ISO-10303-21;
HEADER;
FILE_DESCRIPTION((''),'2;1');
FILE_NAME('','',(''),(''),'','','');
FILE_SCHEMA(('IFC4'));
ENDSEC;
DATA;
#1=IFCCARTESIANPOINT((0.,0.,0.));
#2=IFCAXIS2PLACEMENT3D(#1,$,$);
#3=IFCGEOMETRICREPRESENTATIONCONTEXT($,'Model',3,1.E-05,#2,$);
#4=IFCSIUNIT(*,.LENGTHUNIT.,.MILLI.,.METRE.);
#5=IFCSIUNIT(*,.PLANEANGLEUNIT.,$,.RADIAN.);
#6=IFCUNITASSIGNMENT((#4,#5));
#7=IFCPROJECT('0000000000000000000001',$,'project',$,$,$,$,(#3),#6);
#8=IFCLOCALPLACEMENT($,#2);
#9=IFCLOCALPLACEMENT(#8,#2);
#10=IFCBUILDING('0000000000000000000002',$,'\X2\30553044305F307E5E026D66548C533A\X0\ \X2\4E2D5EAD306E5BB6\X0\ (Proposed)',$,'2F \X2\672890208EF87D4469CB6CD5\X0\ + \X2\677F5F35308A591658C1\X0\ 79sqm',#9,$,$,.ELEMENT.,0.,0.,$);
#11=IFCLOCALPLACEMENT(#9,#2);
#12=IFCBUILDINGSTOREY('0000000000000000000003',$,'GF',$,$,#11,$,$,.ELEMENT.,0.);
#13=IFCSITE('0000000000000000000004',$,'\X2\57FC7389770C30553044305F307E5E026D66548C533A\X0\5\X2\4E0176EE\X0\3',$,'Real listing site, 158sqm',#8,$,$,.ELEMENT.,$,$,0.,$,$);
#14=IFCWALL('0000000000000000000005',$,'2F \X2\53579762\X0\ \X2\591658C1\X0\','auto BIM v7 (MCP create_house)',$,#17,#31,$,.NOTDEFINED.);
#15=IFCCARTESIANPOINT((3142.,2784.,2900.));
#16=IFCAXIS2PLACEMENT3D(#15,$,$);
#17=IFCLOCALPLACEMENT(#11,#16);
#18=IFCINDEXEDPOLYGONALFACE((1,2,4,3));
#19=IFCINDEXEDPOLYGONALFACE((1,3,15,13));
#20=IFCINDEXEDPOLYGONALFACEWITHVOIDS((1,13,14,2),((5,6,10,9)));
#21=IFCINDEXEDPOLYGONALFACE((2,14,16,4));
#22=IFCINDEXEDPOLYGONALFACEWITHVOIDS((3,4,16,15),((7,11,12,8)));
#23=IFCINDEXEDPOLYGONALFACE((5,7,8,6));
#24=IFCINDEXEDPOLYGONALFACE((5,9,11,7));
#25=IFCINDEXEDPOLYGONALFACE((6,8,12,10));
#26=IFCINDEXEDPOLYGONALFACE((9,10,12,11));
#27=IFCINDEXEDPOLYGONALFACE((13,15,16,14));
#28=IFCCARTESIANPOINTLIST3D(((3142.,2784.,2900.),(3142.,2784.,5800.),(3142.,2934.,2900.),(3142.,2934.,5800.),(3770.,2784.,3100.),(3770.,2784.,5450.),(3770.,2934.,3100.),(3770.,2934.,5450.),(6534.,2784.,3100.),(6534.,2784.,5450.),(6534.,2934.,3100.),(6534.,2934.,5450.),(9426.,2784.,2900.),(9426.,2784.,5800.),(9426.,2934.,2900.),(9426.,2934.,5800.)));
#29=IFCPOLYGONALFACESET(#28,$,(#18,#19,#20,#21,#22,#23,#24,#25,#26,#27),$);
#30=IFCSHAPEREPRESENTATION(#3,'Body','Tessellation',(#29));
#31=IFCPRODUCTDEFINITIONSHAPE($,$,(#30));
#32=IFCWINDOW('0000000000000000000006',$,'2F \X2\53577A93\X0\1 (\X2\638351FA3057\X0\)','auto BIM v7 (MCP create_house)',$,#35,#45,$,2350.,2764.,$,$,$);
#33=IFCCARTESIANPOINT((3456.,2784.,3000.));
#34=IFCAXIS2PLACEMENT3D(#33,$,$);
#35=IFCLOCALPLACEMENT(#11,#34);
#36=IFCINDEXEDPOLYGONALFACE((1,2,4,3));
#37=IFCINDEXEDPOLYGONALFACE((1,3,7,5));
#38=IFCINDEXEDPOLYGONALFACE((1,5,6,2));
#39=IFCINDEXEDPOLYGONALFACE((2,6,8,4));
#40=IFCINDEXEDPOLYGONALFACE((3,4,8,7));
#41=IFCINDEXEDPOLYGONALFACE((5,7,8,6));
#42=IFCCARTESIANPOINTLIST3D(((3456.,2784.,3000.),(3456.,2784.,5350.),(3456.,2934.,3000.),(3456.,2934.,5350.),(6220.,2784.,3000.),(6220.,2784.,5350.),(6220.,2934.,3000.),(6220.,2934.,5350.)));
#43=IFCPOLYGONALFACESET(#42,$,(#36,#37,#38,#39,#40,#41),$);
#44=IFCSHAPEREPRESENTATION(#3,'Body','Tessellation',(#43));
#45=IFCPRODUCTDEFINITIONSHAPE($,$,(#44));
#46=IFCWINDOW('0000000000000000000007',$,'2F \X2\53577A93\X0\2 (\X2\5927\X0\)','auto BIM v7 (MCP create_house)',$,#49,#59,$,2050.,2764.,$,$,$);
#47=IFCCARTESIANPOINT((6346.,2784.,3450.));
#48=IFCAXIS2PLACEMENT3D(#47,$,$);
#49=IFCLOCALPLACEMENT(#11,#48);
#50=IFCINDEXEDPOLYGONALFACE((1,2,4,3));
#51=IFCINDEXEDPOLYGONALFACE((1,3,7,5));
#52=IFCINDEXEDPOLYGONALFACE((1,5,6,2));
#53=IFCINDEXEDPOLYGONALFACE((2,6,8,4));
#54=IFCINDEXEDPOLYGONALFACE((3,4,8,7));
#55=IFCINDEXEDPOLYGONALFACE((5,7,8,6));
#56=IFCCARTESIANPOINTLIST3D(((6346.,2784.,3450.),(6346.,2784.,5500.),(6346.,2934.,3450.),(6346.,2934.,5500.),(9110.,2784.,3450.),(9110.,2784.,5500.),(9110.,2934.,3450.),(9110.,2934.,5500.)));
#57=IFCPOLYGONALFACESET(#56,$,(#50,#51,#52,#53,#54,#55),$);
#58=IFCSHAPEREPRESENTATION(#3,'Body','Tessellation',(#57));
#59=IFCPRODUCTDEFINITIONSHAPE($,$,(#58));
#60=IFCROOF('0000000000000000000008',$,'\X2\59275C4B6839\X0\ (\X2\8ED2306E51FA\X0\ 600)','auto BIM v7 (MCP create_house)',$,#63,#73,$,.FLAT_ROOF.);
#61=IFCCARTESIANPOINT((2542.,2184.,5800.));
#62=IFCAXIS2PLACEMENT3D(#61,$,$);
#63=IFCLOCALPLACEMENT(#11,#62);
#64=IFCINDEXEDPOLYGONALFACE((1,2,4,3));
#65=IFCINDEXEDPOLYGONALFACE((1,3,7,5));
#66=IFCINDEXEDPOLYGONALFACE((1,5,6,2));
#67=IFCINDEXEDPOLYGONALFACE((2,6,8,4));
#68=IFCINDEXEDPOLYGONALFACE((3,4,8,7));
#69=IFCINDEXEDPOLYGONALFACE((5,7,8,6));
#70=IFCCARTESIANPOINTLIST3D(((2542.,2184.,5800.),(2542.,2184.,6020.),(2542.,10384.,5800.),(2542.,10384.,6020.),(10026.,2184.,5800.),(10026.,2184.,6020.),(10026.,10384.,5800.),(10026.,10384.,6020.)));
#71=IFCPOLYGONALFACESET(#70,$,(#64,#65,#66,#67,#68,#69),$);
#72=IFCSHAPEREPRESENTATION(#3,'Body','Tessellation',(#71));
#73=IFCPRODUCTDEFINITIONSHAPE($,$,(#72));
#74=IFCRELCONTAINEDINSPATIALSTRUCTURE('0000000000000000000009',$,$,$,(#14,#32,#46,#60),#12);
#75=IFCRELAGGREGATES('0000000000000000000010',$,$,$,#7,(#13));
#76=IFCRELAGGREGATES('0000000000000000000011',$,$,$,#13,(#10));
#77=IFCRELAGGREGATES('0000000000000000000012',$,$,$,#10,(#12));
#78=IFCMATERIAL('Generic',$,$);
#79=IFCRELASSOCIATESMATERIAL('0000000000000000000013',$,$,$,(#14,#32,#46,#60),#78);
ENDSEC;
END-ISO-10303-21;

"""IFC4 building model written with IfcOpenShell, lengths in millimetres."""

from ifc_helpers import new_model, si_unit, frame, frame_2d, origin, place, context, project, spatial, rectangle, extrude, material, element, fill, save


model = new_model("IFC4")

# Units and contexts
model_context = context("Model", 3, precision=1e-05, world=origin())
ifc_project = project(units=[si_unit("LENGTHUNIT", "METRE", prefix="MILLI"), si_unit("PLANEANGLEUNIT", "RADIAN")], contexts=[model_context])

# Site, building, storey
site_placement = place(None, origin())
site = spatial("IfcSite", under=ifc_project, at=site_placement, Name="埼玉県さいたま市浦和区5丁目3", ObjectType="Real listing site, 158sqm", CompositionType="ELEMENT", RefElevation=0.0)
building_placement = place(site_placement, origin())
building = spatial("IfcBuilding", under=site, at=building_placement, Name="さいたま市浦和区 中庭の家 (Proposed)", ObjectType="2F 木造軸組構法 + 板張り外壁 79sqm", CompositionType="ELEMENT", ElevationOfRefHeight=0.0, ElevationOfTerrain=0.0)
storey_placement = place(building_placement, origin())
storey = spatial("IfcBuildingStorey", under=building, at=storey_placement, Name="GF", CompositionType="ELEMENT", Elevation=0.0)

# Shared definitions
ifc_material = material(Name="Generic")

# Wall, openings, windows
wall_1_placement = place(storey_placement, frame((3142.0, 2784.0, 2900.0)))
wall_1 = element("IfcWall", 1, at=wall_1_placement, inside=storey, material=ifc_material, Name="2F 南面 外壁", Description="auto BIM v7 (MCP create_house)", PredefinedType="NOTDEFINED", context=model_context, shape_type="SweptSolid", body=[
    extrude(rectangle(XDim=6284.0, YDim=150.0, at=frame_2d((3142.0, 75.0))), frame((3142.0, 2784.0, 2900.0)), (0.0, 0.0, 1.0), 2900.0),
])
opening_1_placement = place(storey_placement, frame((3456.0, 2784.0, 3000.0)))
opening_1 = element("IfcOpeningElement", 2, at=opening_1_placement, cuts=wall_1, PredefinedType="NOTDEFINED", context=model_context, shape_type="SweptSolid", body=[
    extrude(rectangle(XDim=2764.0, YDim=150.0, at=frame_2d((1382.0, 75.0))), frame((3456.0, 2784.0, 3000.0)), (0.0, 0.0, 1.0), 2350.0),
])
opening_2_placement = place(storey_placement, frame((6346.0, 2784.0, 3450.0)))
opening_2 = element("IfcOpeningElement", 3, at=opening_2_placement, cuts=wall_1, PredefinedType="NOTDEFINED", context=model_context, shape_type="SweptSolid", body=[
    extrude(rectangle(XDim=2764.0, YDim=150.0, at=frame_2d((1382.0, 75.0))), frame((6346.0, 2784.0, 3450.0)), (0.0, 0.0, 1.0), 2050.0),
])
window_1_placement = place(storey_placement, frame((3456.0, 2784.0, 3000.0)))
window_1 = element("IfcWindow", 4, at=window_1_placement, inside=storey, material=ifc_material, Name="2F 南窓1 (掃出し)", Description="auto BIM v7 (MCP create_house)", OverallHeight=2350.0, OverallWidth=2764.0, context=model_context, shape_type="SweptSolid", body=[
    extrude(rectangle(XDim=2764.0, YDim=150.0, at=frame_2d((1382.0, 75.0))), frame((3456.0, 2784.0, 3000.0)), (0.0, 0.0, 1.0), 2350.0),
])
fill(opening_1, window_1)
window_2_placement = place(storey_placement, frame((6346.0, 2784.0, 3450.0)))
window_2 = element("IfcWindow", 5, at=window_2_placement, inside=storey, material=ifc_material, Name="2F 南窓2 (大)", Description="auto BIM v7 (MCP create_house)", OverallHeight=2050.0, OverallWidth=2764.0, context=model_context, shape_type="SweptSolid", body=[
    extrude(rectangle(XDim=2764.0, YDim=150.0, at=frame_2d((1382.0, 75.0))), frame((6346.0, 2784.0, 3450.0)), (0.0, 0.0, 1.0), 2050.0),
])
fill(opening_2, window_2)

# Roof
roof_placement = place(storey_placement, frame((2542.0, 2184.0, 5800.0)))
element("IfcRoof", 6, at=roof_placement, inside=storey, material=ifc_material, Name="大屋根 (軒の出 600)", Description="auto BIM v7 (MCP create_house)", PredefinedType="FLAT_ROOF", context=model_context, shape_type="SweptSolid", body=[
    extrude(rectangle(XDim=7484.0, YDim=8200.0, at=frame_2d((3742.0, 4100.0))), frame((2542.0, 2184.0, 5800.0)), (0.0, 0.0, 1.0), 220.0),
])

save(model, "model.ifc")
